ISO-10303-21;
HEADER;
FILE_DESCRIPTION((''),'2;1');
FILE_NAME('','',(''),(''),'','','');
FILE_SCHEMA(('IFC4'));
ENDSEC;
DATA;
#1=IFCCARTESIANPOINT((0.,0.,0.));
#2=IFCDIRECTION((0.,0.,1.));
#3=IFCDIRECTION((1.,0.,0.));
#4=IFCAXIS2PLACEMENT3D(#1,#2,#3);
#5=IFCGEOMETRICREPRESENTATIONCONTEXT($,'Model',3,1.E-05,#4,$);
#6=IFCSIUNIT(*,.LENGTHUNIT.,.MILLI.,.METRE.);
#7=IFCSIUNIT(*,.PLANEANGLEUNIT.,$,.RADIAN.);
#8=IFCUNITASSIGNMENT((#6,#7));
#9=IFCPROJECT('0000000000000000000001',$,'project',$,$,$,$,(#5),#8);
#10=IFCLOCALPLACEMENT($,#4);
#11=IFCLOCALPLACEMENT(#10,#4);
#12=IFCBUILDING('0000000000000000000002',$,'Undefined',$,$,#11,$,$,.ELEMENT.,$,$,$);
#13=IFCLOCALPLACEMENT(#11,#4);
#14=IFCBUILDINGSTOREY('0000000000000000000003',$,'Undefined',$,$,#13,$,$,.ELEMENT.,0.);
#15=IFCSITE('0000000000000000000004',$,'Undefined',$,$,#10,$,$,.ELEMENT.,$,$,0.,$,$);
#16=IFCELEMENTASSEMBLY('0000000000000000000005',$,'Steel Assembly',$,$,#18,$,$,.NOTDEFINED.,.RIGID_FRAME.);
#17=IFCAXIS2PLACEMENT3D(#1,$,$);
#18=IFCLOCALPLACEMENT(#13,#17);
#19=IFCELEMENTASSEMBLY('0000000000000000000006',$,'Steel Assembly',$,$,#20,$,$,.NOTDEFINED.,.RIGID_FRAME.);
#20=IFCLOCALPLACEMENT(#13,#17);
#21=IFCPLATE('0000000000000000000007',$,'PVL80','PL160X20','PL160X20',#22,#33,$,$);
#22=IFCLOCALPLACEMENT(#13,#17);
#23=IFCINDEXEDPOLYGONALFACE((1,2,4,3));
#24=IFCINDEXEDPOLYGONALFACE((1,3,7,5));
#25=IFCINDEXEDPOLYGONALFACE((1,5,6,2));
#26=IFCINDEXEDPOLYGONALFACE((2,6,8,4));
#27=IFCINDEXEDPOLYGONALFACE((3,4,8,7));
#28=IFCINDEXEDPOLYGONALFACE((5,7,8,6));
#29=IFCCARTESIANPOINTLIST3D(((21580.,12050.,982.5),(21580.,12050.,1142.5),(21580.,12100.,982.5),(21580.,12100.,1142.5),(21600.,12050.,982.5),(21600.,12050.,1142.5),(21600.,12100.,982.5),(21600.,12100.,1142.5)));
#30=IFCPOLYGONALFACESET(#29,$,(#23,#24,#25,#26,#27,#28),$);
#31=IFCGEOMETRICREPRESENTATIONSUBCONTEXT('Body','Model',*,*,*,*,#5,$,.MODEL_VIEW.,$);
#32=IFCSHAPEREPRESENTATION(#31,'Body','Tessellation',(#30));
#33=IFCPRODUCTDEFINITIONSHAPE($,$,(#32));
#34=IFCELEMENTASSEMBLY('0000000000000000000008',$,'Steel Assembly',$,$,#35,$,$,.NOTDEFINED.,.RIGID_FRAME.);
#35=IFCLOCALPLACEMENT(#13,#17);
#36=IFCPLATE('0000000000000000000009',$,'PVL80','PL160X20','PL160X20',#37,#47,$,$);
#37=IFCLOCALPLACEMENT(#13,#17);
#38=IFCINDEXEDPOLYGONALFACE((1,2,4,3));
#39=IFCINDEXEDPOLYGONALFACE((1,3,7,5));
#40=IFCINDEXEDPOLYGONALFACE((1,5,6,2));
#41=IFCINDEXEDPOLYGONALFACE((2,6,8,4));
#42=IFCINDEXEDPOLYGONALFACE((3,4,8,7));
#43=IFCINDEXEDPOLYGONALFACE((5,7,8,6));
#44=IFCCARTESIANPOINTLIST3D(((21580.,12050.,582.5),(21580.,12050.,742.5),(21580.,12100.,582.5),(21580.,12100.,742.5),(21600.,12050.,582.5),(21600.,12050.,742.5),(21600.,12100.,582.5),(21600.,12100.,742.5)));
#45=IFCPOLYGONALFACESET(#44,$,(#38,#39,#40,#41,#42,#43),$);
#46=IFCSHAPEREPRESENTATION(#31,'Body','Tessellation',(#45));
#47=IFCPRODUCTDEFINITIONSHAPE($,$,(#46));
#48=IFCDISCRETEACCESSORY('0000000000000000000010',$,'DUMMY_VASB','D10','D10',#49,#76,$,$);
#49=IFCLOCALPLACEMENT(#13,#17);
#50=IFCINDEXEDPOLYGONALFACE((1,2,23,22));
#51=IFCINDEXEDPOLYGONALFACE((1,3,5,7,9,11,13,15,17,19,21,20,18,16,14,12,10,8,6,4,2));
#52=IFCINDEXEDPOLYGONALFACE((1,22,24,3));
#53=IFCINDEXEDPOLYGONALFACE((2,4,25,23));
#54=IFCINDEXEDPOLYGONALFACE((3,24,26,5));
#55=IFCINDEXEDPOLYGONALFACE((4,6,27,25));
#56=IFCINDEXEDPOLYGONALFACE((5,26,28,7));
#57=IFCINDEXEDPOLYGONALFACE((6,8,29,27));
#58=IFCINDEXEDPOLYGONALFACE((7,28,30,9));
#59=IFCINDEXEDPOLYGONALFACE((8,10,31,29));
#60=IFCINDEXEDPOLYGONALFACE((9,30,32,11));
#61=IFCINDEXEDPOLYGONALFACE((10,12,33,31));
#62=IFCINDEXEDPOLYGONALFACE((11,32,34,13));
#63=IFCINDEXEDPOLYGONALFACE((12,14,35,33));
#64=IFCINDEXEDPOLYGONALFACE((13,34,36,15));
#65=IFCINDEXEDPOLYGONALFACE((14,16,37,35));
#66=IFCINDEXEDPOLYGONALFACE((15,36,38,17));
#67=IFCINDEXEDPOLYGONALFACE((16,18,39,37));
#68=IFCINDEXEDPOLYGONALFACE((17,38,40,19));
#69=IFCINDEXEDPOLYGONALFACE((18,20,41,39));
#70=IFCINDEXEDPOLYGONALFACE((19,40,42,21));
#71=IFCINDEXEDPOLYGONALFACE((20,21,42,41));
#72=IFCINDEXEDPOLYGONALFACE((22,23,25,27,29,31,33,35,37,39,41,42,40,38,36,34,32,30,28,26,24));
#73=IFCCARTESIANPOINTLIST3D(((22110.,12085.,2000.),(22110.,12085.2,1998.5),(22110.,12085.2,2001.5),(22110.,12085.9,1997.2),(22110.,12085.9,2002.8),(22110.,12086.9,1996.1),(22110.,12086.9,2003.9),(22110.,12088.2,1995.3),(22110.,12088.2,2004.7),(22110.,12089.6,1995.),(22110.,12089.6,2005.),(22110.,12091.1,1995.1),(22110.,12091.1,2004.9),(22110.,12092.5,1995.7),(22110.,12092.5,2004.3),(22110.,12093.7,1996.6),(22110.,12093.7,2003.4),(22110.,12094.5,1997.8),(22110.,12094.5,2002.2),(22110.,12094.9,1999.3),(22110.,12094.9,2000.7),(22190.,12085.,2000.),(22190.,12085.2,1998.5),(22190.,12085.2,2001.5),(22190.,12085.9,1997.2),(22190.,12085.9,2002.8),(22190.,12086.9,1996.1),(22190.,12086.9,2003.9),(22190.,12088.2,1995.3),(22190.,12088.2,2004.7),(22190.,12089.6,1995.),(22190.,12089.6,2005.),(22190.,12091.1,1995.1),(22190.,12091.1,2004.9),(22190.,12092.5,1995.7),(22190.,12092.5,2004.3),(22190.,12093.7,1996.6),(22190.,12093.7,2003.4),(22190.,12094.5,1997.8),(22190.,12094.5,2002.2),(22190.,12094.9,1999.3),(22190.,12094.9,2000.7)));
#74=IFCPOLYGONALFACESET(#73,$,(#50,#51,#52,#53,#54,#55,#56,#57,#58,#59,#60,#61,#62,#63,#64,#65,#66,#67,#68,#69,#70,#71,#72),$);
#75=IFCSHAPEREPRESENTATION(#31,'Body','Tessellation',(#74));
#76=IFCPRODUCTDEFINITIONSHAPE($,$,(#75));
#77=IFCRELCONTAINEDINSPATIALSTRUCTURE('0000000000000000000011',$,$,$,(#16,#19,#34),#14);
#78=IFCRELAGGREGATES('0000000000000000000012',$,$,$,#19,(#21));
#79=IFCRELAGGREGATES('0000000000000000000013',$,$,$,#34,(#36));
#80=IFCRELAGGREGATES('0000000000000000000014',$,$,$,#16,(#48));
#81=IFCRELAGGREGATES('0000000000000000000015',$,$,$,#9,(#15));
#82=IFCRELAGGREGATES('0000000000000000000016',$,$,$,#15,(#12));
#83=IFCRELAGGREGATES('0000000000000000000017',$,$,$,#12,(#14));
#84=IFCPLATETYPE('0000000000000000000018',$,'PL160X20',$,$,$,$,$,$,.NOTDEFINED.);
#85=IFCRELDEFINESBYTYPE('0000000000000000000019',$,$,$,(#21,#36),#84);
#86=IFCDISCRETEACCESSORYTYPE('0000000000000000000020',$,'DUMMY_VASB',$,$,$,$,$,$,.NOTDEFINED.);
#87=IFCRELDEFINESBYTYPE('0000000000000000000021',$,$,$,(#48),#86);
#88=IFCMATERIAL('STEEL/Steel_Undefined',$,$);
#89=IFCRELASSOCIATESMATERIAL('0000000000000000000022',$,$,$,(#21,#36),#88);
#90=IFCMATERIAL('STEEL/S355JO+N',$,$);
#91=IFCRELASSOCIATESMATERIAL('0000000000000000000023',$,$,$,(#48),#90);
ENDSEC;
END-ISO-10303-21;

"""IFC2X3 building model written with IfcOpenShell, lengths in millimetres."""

from ifc_helpers import new_model, si_unit, frame, origin_with_axes, origin_2d_with_axis, place, context, subcontext, project, spatial, polyline, circle, outline, extrude, material, type_object, element, aggregate, save


model = new_model("IFC2X3")

# Units and contexts
model_context = context("Model", 3, precision=1e-05, world=origin_with_axes())
body_context = subcontext(model_context, "Body", "Model", "MODEL_VIEW")
ifc_project = project(units=[si_unit("LENGTHUNIT", "METRE", prefix="MILLI"), si_unit("PLANEANGLEUNIT", "RADIAN")], contexts=[model_context])

# Site, building, storey
site_placement = place(None, origin_with_axes())
site = spatial("IfcSite", under=ifc_project, at=site_placement, Name="Undefined", CompositionType="ELEMENT", RefElevation=0.0)
building_placement = place(site_placement, origin_with_axes())
building = spatial("IfcBuilding", under=site, at=building_placement, Name="Undefined", CompositionType="ELEMENT")
storey_placement = place(building_placement, origin_with_axes())
storey = spatial("IfcBuildingStorey", under=building, at=storey_placement, Name="Undefined", CompositionType="ELEMENT", Elevation=0.0)

# Shared definitions
ifc_material_1 = material(Name="STEEL/Steel_Undefined")

# Element assembly
assembly_1_placement = place(storey_placement, origin_with_axes())
assembly_1 = element("IfcElementAssembly", 1, at=assembly_1_placement, inside=storey, Name="Steel Assembly", AssemblyPlace="NOTDEFINED", PredefinedType="RIGID_FRAME")
ifc_material_2 = material(Name="STEEL/S355JO+N")

# Element assemblies, plates
plate_type = type_object("IfcPlateType", Name="PL160X20", PredefinedType="NOTDEFINED")
assembly_2_placement = place(storey_placement, origin_with_axes())
assembly_2 = element("IfcElementAssembly", 2, at=assembly_2_placement, inside=storey, Name="Steel Assembly", AssemblyPlace="NOTDEFINED", PredefinedType="RIGID_FRAME")
plate_1_placement = place(assembly_2_placement, frame((21580.0, 12050.0, 1062.5), z_axis=(0.0, 0.0, -1.0), x_axis=(0.0, 1.0, 0.0)))
plate_1 = element("IfcPlate", 3, at=plate_1_placement, type_object=plate_type, material=ifc_material_1, Name="PVL80", Description="PL160X20", ObjectType="PL160X20", context=body_context, shape_type="SweptSolid", body=[
    extrude(outline(polyline([(0.0, 0.0), (50.0, 0.0), (50.0, 20.0), (0.0, 20.0), (0.0, 0.0)])), frame((0.0, 0.0, -80.0), z_axis=(0.0, 0.0, 1.0), x_axis=(1.0, 0.0, 0.0)), (0.0, 0.0, 1.0), 160.0),
])
assembly_3_placement = place(storey_placement, origin_with_axes())
assembly_3 = element("IfcElementAssembly", 4, at=assembly_3_placement, inside=storey, Name="Steel Assembly", AssemblyPlace="NOTDEFINED", PredefinedType="RIGID_FRAME")
plate_2_placement = place(assembly_3_placement, frame((21580.0, 12050.0, 662.5), z_axis=(0.0, 0.0, -1.0), x_axis=(0.0, 1.0, 0.0)))
plate_2 = element("IfcPlate", 5, at=plate_2_placement, type_object=plate_type, material=ifc_material_1, Name="PVL80", Description="PL160X20", ObjectType="PL160X20", context=body_context, shape_type="SweptSolid", body=[
    extrude(outline(polyline([(0.0, 0.0), (50.0, 0.0), (50.0, 20.0), (0.0, 20.0), (0.0, 0.0)])), frame((0.0, 0.0, -80.0), z_axis=(0.0, 0.0, 1.0), x_axis=(1.0, 0.0, 0.0)), (0.0, 0.0, 1.0), 160.0),
])

aggregate(assembly_2, [plate_1])
aggregate(assembly_3, [plate_2])

# Discrete accessory
discrete_accessory_type = type_object("IfcDiscreteAccessoryType", Name="DUMMY_VASB")
discrete_accessory_placement = place(assembly_1_placement, frame((22110.0, 12090.0, 2000.0), z_axis=(0.0, 0.0, 1.0), x_axis=(1.0, 0.0, 0.0)))
discrete_accessory = element("IfcDiscreteAccessory", 6, at=discrete_accessory_placement, type_object=discrete_accessory_type, material=ifc_material_2, Name="DUMMY_VASB", Description="D10", ObjectType="D10", context=body_context, shape_type="SweptSolid", body=[
    extrude(circle(Radius=5.0, at=origin_2d_with_axis()), frame((80.0, 0.0, 0.0), z_axis=(-1.0, 0.0, 0.0), x_axis=(0.0, -1.0, 0.0)), (0.0, 0.0, 1.0), 80.0),
])
aggregate(assembly_1, [discrete_accessory])

save(model, "model.ifc")
